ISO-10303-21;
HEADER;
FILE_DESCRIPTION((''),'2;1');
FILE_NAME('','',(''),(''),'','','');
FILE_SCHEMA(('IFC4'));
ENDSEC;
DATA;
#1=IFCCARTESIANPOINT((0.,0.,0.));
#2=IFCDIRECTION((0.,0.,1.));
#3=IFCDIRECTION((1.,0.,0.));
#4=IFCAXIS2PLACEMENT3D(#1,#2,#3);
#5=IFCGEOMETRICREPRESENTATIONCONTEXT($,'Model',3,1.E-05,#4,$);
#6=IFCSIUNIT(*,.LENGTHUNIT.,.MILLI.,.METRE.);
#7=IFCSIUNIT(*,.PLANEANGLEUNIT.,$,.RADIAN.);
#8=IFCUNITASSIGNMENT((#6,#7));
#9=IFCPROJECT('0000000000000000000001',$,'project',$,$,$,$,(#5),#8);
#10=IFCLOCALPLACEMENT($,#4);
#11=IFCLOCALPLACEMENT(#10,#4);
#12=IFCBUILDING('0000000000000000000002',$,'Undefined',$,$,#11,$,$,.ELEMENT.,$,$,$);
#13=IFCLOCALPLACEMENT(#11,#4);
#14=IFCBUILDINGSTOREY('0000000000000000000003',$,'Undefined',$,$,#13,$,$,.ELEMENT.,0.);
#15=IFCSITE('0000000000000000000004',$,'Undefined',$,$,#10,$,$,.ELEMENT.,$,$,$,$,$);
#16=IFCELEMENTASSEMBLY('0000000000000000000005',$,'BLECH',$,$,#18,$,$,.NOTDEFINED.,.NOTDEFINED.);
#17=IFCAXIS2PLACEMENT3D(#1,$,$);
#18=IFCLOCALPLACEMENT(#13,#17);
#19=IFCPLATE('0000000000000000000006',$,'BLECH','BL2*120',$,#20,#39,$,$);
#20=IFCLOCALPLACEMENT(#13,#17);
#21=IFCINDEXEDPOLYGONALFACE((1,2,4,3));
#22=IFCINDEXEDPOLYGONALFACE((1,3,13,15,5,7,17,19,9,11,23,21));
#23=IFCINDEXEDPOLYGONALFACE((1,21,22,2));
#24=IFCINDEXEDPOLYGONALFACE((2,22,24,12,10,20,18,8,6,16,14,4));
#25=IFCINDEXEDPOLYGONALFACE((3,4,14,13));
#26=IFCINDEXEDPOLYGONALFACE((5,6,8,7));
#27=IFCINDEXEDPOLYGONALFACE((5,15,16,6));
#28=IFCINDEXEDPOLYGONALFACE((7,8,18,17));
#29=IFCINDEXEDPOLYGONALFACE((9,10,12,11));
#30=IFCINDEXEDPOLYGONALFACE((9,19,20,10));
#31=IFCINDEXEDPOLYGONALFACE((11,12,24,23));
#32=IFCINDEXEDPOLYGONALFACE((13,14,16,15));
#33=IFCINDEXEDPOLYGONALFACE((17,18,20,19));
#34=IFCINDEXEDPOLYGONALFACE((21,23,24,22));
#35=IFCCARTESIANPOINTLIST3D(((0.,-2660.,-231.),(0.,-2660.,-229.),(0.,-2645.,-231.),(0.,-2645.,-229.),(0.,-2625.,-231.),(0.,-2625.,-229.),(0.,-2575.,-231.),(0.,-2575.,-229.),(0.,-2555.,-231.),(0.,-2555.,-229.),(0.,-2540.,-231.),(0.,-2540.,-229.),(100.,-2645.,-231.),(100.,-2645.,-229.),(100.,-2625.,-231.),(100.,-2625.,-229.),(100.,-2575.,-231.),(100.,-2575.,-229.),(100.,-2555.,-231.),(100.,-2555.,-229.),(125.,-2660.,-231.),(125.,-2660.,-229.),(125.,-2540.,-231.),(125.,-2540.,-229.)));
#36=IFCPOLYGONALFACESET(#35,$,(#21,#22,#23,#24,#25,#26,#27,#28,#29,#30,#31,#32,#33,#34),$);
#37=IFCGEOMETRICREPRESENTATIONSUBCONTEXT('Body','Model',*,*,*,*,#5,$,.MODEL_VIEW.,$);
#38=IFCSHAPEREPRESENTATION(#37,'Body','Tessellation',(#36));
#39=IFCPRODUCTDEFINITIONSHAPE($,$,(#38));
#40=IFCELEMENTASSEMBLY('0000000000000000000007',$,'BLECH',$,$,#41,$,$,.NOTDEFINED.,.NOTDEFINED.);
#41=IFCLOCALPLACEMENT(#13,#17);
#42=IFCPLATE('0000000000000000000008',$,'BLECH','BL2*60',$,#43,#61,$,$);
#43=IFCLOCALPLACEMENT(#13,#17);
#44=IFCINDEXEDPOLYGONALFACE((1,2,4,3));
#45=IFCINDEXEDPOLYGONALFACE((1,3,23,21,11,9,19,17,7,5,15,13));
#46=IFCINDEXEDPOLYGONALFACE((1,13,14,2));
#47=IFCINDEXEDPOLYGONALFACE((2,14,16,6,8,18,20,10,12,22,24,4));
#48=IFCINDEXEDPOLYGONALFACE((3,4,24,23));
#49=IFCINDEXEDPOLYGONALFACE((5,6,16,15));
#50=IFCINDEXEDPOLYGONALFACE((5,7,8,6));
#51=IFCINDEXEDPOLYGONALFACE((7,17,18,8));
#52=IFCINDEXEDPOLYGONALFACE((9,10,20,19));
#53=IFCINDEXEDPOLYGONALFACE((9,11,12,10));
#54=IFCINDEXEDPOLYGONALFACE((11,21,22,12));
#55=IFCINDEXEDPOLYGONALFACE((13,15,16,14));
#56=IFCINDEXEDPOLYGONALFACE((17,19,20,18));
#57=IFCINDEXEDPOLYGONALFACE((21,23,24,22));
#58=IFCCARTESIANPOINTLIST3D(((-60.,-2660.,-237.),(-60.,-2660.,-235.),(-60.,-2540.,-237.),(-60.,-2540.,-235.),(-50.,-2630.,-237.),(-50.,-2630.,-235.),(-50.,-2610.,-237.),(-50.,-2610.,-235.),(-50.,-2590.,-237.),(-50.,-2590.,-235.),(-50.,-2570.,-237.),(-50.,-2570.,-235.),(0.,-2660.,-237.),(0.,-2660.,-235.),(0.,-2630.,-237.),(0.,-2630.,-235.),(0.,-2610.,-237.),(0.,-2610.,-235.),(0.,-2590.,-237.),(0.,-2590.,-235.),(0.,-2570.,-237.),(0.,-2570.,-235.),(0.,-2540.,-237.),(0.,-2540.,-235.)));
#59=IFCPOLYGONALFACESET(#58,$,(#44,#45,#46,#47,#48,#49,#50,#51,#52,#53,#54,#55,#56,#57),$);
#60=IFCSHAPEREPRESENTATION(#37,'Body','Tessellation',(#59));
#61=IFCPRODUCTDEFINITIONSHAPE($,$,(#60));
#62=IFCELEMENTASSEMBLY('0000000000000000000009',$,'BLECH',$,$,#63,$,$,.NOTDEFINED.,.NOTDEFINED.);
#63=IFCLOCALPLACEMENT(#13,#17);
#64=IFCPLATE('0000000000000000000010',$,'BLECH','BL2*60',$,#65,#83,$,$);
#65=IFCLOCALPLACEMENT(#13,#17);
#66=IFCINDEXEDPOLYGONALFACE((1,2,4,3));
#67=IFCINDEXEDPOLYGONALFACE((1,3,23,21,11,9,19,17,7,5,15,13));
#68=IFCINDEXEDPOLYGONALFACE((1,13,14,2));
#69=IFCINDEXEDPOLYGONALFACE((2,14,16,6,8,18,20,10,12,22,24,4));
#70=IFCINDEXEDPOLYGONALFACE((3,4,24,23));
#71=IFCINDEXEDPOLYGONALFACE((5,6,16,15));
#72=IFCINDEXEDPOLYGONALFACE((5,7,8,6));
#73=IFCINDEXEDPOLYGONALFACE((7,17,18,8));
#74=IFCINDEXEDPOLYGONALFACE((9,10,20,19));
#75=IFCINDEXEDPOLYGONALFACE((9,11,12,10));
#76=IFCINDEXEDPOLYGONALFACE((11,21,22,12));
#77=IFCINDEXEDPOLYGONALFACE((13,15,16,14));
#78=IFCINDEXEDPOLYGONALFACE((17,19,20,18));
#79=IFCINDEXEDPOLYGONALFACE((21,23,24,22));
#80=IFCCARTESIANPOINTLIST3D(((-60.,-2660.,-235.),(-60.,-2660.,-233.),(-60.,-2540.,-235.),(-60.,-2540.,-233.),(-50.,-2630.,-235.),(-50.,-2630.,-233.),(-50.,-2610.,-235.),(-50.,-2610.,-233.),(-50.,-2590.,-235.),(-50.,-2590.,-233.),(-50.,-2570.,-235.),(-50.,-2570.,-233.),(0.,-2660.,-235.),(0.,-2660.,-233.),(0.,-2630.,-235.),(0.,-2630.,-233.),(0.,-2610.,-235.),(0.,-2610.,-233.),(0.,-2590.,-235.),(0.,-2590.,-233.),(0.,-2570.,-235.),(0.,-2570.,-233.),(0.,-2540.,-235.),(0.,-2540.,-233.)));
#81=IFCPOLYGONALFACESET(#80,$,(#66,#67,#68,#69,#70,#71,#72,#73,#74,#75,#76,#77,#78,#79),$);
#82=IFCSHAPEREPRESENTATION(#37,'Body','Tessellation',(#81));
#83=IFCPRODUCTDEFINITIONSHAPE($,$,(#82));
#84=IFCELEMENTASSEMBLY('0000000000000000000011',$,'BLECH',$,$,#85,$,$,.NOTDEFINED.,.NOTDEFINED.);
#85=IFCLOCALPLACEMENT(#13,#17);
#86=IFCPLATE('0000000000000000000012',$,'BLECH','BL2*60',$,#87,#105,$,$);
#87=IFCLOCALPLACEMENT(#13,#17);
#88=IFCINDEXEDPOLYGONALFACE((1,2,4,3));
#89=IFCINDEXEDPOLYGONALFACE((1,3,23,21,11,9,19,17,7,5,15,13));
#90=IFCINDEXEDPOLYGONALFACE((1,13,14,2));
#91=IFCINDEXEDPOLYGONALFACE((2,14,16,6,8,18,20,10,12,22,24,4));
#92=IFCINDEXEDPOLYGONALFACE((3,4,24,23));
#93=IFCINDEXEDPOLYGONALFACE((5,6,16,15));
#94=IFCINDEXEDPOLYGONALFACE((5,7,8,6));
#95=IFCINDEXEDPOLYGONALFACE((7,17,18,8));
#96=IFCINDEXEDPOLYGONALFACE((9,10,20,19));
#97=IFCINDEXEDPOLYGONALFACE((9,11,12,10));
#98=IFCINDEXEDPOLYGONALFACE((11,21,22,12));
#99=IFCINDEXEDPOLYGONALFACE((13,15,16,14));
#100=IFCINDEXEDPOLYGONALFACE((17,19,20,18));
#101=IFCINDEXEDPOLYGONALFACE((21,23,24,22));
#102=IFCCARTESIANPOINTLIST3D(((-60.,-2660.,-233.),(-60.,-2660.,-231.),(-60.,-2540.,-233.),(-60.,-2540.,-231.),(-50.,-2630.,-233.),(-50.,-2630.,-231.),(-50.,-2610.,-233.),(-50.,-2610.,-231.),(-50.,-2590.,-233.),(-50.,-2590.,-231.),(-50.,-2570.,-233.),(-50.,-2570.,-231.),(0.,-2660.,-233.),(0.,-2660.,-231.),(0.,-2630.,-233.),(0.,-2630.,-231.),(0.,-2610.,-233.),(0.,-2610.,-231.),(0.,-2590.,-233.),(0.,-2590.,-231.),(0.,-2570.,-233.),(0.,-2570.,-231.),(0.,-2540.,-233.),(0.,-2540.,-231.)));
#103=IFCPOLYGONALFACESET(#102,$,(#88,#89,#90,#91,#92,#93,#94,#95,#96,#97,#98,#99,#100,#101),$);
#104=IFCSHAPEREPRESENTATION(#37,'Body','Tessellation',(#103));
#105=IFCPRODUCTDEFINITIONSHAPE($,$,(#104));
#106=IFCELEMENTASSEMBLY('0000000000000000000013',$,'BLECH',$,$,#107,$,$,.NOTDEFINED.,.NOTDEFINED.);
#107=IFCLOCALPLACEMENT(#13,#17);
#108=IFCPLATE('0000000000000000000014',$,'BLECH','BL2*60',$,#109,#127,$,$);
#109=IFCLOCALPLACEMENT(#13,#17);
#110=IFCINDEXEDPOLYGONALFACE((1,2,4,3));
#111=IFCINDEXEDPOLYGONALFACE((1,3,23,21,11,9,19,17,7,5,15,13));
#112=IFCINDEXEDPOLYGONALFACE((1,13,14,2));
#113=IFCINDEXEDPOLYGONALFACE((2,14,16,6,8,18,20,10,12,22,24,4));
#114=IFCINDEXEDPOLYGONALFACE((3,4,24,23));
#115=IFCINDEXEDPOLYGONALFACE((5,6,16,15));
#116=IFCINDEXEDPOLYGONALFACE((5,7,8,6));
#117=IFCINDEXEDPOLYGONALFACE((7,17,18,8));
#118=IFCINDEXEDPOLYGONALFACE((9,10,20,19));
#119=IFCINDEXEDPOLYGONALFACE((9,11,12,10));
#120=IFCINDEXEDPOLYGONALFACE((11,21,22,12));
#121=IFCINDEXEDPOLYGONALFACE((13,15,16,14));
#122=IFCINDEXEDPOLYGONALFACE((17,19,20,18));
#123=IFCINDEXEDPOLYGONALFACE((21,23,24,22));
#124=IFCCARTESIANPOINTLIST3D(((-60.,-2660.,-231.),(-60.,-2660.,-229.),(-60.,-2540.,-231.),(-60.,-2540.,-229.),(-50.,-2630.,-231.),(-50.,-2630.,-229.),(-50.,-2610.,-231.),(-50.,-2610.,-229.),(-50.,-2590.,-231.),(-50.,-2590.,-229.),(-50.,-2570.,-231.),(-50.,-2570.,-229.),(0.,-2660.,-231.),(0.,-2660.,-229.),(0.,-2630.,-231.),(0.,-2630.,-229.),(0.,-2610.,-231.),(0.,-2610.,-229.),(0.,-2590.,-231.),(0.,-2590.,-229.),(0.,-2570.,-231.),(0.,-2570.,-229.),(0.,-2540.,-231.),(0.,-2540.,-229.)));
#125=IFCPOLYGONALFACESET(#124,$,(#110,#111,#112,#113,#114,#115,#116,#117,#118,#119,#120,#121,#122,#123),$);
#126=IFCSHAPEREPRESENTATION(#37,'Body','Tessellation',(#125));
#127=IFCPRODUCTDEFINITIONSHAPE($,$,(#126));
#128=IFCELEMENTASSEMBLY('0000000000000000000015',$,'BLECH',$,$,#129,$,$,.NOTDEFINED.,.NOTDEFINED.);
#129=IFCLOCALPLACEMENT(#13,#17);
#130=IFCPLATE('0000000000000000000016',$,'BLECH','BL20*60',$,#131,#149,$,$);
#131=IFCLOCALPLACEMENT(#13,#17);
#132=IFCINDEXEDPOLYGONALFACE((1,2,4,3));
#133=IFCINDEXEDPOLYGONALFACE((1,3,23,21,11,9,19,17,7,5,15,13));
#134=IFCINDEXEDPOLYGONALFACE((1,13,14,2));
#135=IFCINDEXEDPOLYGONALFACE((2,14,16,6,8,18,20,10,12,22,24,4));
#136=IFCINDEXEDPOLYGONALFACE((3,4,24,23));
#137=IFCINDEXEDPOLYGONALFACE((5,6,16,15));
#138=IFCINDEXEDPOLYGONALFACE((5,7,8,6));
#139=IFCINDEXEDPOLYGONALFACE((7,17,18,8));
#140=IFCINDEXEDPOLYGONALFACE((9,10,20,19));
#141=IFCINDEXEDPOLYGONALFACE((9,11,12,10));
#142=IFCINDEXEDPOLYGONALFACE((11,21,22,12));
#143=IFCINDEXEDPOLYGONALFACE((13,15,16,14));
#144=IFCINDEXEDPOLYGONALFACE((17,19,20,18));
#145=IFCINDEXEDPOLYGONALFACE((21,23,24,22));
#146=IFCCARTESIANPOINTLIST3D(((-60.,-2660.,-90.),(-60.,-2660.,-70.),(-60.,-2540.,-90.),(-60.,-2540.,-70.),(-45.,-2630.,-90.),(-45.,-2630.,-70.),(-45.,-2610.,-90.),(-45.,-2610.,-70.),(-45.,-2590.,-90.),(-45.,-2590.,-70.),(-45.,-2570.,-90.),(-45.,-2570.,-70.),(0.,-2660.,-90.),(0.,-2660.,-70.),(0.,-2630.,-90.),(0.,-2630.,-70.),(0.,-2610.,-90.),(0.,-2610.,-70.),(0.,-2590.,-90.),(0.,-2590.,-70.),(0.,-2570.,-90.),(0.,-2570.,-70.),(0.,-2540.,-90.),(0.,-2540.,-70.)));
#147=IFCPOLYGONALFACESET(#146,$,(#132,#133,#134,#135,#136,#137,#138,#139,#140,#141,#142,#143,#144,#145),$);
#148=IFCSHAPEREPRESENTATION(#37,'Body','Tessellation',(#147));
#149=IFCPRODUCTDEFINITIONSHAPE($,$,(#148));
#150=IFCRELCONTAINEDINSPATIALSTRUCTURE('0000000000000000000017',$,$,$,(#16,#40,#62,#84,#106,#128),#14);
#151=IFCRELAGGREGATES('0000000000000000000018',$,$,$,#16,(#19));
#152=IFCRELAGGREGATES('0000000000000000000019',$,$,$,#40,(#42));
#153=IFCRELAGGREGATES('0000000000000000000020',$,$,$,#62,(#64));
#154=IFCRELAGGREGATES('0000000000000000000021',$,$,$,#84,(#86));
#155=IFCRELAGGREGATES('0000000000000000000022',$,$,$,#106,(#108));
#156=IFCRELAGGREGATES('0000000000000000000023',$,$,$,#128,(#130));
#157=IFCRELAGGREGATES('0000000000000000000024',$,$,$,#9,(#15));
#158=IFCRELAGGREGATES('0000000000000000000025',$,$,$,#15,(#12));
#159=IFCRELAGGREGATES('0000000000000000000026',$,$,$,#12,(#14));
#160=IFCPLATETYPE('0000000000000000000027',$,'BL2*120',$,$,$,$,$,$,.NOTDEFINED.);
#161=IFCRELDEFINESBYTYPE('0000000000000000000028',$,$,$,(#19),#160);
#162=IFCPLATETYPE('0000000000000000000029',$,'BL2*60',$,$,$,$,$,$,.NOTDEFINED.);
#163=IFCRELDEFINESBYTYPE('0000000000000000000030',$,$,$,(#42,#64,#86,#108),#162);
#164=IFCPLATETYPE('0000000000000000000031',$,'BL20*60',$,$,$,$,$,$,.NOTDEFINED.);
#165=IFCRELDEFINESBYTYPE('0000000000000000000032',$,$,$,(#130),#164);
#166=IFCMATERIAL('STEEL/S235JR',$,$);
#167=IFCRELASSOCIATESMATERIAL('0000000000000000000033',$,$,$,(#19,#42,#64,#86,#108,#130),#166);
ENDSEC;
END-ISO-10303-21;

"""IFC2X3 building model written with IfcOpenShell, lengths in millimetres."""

from ifc_helpers import new_model, si_unit, frame, origin_with_axes, place, context, subcontext, project, spatial, polyline, outline, extrude, material, type_object, element, aggregate, save


model = new_model("IFC2X3")

# Units and contexts
model_context = context("Model", 3, precision=1e-05, world=origin_with_axes())
body_context = subcontext(model_context, "Body", "Model", "MODEL_VIEW")
ifc_project = project(units=[si_unit("LENGTHUNIT", "METRE", prefix="MILLI"), si_unit("PLANEANGLEUNIT", "RADIAN")], contexts=[model_context])

# Site, building, storey
site_placement = place(None, origin_with_axes())
site = spatial("IfcSite", under=ifc_project, at=site_placement, Name="Undefined", CompositionType="ELEMENT")
building_placement = place(site_placement, origin_with_axes())
building = spatial("IfcBuilding", under=site, at=building_placement, Name="Undefined", CompositionType="ELEMENT")
storey_placement = place(building_placement, origin_with_axes())
storey = spatial("IfcBuildingStorey", under=building, at=storey_placement, Name="Undefined", CompositionType="ELEMENT", Elevation=0.0)

# Shared definitions
ifc_material = material(Name="STEEL/S235JR")

# Element assemblies, plates
plate_type_1 = type_object("IfcPlateType", Name="BL2*120", PredefinedType="NOTDEFINED")
assembly_1_placement = place(storey_placement, origin_with_axes())
assembly_1 = element("IfcElementAssembly", 1, at=assembly_1_placement, inside=storey, Name="BLECH", AssemblyPlace="NOTDEFINED", PredefinedType="NOTDEFINED")
plate_1_placement = place(assembly_1_placement, frame((125.0, -2540.0, -230.0), z_axis=(0.0, 0.0, 1.0), x_axis=(-1.0, 0.0, 0.0)))
plate_1 = element("IfcPlate", 2, at=plate_1_placement, type_object=plate_type_1, material=ifc_material, Name="BLECH", Description="BL2*120", context=body_context, shape_type="SweptSolid", body=[
    extrude(outline(polyline([(0.0, 0.0), (125.0, 0.0), (125.0, 15.0), (25.0, 15.0), (25.0, 35.0), (125.0, 35.0), (125.0, 85.0), (25.0, 85.0), (25.0, 105.0), (125.0, 105.0), (125.0, 120.0), (0.0, 120.0), (0.0, 0.0)])), frame((0.0, 0.0, -1.0), z_axis=(0.0, 0.0, 1.0), x_axis=(1.0, 0.0, 0.0)), (0.0, 0.0, 1.0), 2.0),
])
aggregate(assembly_1, [plate_1])
assembly_2_placement = place(storey_placement, origin_with_axes())
assembly_2 = element("IfcElementAssembly", 3, at=assembly_2_placement, inside=storey, Name="BLECH", AssemblyPlace="NOTDEFINED", PredefinedType="NOTDEFINED")
plate_type_2 = type_object("IfcPlateType", Name="BL2*60", PredefinedType="NOTDEFINED")
plate_2_placement = place(assembly_2_placement, frame((-60.0, -2540.0, -236.0), z_axis=(0.0, 0.0, -1.0), x_axis=(1.0, 0.0, 0.0)))
plate_2 = element("IfcPlate", 4, at=plate_2_placement, type_object=plate_type_2, material=ifc_material, Name="BLECH", Description="BL2*60", context=body_context, shape_type="SweptSolid", body=[
    extrude(outline(polyline([(0.0, 0.0), (60.0, 0.0), (60.0, 30.0), (10.0, 30.0), (10.0, 50.0), (60.0, 50.0), (60.0, 70.0), (10.0, 70.0), (10.0, 90.0), (60.0, 90.0), (60.0, 120.0), (0.0, 120.0), (0.0, 0.0)])), frame((0.0, 0.0, -1.0), z_axis=(0.0, 0.0, 1.0), x_axis=(1.0, 0.0, 0.0)), (0.0, 0.0, 1.0), 2.0),
])
aggregate(assembly_2, [plate_2])
assembly_3_placement = place(storey_placement, origin_with_axes())
assembly_3 = element("IfcElementAssembly", 5, at=assembly_3_placement, inside=storey, Name="BLECH", AssemblyPlace="NOTDEFINED", PredefinedType="NOTDEFINED")
plate_3_placement = place(assembly_3_placement, frame((-60.0, -2540.0, -234.0), z_axis=(0.0, 0.0, -1.0), x_axis=(1.0, 0.0, 0.0)))
plate_3 = element("IfcPlate", 6, at=plate_3_placement, type_object=plate_type_2, material=ifc_material, Name="BLECH", Description="BL2*60", context=body_context, shape_type="SweptSolid", body=[
    extrude(outline(polyline([(0.0, 0.0), (60.0, 0.0), (60.0, 30.0), (10.0, 30.0), (10.0, 50.0), (60.0, 50.0), (60.0, 70.0), (10.0, 70.0), (10.0, 90.0), (60.0, 90.0), (60.0, 120.0), (0.0, 120.0), (0.0, 0.0)])), frame((0.0, 0.0, -1.0), z_axis=(0.0, 0.0, 1.0), x_axis=(1.0, 0.0, 0.0)), (0.0, 0.0, 1.0), 2.0),
])
aggregate(assembly_3, [plate_3])
assembly_4_placement = place(storey_placement, origin_with_axes())
assembly_4 = element("IfcElementAssembly", 7, at=assembly_4_placement, inside=storey, Name="BLECH", AssemblyPlace="NOTDEFINED", PredefinedType="NOTDEFINED")
plate_4_placement = place(assembly_4_placement, frame((-60.0, -2540.0, -232.0), z_axis=(0.0, 0.0, -1.0), x_axis=(1.0, 0.0, 0.0)))
plate_4 = element("IfcPlate", 8, at=plate_4_placement, type_object=plate_type_2, material=ifc_material, Name="BLECH", Description="BL2*60", context=body_context, shape_type="SweptSolid", body=[
    extrude(outline(polyline([(0.0, 0.0), (60.0, 0.0), (60.0, 30.0), (10.0, 30.0), (10.0, 50.0), (60.0, 50.0), (60.0, 70.0), (10.0, 70.0), (10.0, 90.0), (60.0, 90.0), (60.0, 120.0), (0.0, 120.0), (0.0, 0.0)])), frame((0.0, 0.0, -1.0), z_axis=(0.0, 0.0, 1.0), x_axis=(1.0, 0.0, 0.0)), (0.0, 0.0, 1.0), 2.0),
])
aggregate(assembly_4, [plate_4])
assembly_5_placement = place(storey_placement, origin_with_axes())
assembly_5 = element("IfcElementAssembly", 9, at=assembly_5_placement, inside=storey, Name="BLECH", AssemblyPlace="NOTDEFINED", PredefinedType="NOTDEFINED")
plate_5_placement = place(assembly_5_placement, frame((-60.0, -2540.0, -230.0), z_axis=(0.0, 0.0, -1.0), x_axis=(1.0, 0.0, 0.0)))
plate_5 = element("IfcPlate", 10, at=plate_5_placement, type_object=plate_type_2, material=ifc_material, Name="BLECH", Description="BL2*60", context=body_context, shape_type="SweptSolid", body=[
    extrude(outline(polyline([(0.0, 0.0), (60.0, 0.0), (60.0, 30.0), (10.0, 30.0), (10.0, 50.0), (60.0, 50.0), (60.0, 70.0), (10.0, 70.0), (10.0, 90.0), (60.0, 90.0), (60.0, 120.0), (0.0, 120.0), (0.0, 0.0)])), frame((0.0, 0.0, -1.0), z_axis=(0.0, 0.0, 1.0), x_axis=(1.0, 0.0, 0.0)), (0.0, 0.0, 1.0), 2.0),
])
aggregate(assembly_5, [plate_5])
assembly_6_placement = place(storey_placement, origin_with_axes())
assembly_6 = element("IfcElementAssembly", 11, at=assembly_6_placement, inside=storey, Name="BLECH", AssemblyPlace="NOTDEFINED", PredefinedType="NOTDEFINED")
plate_type_3 = type_object("IfcPlateType", Name="BL20*60", PredefinedType="NOTDEFINED")
plate_6_placement = place(assembly_6_placement, frame((-60.0, -2540.0, -80.0), z_axis=(0.0, 0.0, -1.0), x_axis=(1.0, 0.0, 0.0)))
plate_6 = element("IfcPlate", 12, at=plate_6_placement, type_object=plate_type_3, material=ifc_material, Name="BLECH", Description="BL20*60", context=body_context, shape_type="SweptSolid", body=[
    extrude(outline(polyline([(0.0, 0.0), (60.0, 0.0), (60.0, 30.0), (15.0, 30.0), (15.0, 50.0), (60.0, 50.0), (60.0, 70.0), (15.0, 70.0), (15.0, 90.0), (60.0, 90.0), (60.0, 120.0), (0.0, 120.0), (0.0, 0.0)])), frame((0.0, 0.0, -10.0), z_axis=(0.0, 0.0, 1.0), x_axis=(1.0, 0.0, 0.0)), (0.0, 0.0, 1.0), 20.0),
])
aggregate(assembly_6, [plate_6])

save(model, "model.ifc")
